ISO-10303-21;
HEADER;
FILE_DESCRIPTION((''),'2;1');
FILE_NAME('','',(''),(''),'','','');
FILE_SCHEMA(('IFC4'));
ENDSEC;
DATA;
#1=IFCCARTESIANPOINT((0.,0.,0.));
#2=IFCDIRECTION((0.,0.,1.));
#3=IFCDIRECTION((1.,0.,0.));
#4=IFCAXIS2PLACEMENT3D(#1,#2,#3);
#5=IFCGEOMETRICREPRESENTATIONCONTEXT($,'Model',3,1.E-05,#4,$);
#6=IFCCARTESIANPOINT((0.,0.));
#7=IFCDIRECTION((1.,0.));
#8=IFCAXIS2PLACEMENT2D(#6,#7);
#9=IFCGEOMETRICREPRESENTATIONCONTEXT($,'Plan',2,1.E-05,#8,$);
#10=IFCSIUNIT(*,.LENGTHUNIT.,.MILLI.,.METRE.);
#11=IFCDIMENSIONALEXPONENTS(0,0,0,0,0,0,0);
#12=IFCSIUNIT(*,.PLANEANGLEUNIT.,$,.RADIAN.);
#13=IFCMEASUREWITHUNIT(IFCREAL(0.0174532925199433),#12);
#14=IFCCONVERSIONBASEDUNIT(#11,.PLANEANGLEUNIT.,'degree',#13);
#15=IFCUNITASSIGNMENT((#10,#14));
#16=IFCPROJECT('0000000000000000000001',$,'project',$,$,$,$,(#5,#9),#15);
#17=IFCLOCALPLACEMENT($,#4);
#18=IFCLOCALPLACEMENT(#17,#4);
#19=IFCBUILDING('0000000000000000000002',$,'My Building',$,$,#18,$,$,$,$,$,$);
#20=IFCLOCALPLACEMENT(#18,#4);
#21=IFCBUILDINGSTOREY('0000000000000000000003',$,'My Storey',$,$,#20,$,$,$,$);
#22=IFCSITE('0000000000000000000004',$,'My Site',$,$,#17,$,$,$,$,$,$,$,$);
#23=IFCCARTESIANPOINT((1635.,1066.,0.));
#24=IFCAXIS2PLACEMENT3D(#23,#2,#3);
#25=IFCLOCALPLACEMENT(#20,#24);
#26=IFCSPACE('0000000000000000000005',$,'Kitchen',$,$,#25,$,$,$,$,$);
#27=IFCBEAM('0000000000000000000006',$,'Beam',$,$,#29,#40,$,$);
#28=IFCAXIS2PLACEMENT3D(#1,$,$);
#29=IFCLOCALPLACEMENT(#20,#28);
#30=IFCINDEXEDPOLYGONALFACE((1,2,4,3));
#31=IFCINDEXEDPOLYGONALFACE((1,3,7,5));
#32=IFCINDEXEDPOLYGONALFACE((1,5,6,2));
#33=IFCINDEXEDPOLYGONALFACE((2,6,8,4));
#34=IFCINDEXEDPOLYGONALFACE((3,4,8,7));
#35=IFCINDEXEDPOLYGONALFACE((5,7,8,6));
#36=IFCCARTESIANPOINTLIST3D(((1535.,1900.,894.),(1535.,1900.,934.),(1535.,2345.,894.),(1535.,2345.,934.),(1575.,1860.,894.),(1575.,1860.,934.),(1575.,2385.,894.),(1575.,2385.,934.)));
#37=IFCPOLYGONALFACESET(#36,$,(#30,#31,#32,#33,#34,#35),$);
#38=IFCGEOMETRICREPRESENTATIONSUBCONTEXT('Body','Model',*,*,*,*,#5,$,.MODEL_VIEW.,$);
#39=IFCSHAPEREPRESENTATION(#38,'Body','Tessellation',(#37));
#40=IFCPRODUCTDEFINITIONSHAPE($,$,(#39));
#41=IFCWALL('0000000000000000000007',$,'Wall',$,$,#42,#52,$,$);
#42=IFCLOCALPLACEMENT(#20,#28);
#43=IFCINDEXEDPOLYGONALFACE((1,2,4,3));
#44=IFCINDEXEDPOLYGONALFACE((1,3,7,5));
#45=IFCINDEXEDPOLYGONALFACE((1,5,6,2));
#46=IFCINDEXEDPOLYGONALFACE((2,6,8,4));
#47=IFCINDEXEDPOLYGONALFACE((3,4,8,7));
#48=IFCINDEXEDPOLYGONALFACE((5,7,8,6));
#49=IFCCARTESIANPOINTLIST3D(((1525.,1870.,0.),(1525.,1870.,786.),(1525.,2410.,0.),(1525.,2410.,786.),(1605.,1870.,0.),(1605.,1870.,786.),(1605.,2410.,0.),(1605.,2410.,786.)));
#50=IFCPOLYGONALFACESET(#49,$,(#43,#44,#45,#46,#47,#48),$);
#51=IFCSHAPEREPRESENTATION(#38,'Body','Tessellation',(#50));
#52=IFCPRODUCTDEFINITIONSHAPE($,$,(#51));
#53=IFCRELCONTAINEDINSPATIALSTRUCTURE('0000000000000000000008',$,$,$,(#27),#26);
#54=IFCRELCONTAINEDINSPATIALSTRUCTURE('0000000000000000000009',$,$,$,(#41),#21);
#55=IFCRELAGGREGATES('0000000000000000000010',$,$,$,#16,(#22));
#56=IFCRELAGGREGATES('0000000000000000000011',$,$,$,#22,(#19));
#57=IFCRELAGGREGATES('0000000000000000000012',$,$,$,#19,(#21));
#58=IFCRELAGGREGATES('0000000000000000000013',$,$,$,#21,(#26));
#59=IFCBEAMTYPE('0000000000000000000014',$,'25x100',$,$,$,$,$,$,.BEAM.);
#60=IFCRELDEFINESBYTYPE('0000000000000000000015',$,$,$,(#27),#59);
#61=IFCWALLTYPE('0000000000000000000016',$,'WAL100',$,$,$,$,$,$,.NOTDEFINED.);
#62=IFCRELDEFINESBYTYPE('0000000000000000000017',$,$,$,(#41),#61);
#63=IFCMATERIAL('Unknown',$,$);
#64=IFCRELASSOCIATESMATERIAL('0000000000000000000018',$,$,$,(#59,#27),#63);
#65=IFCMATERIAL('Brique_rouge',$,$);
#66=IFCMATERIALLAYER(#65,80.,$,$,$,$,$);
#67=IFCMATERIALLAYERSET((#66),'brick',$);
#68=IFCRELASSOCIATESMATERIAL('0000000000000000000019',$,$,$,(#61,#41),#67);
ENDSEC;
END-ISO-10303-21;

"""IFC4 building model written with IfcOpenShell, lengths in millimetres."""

from ifc_helpers import new_model, entity, si_unit, converted_unit, frame, origin_with_axes, origin_2d_with_axis, place, context, subcontext, project, spatial, indexed_curve, rectangle, outline, extrude, clip, halfspace, material, layer, layer_set, layer_usage, material_profile, profile_set, profile_usage, type_object, element, save


model = new_model("IFC4")

# Units and contexts
model_context = context("Model", 3, precision=1e-05, world=origin_with_axes())
plan_context = context("Plan", 2, precision=1e-05, world=origin_2d_with_axis())
body_context = subcontext(model_context, "Body", "Model", "MODEL_VIEW")
ifc_project = project(units=[si_unit("LENGTHUNIT", "METRE", prefix="MILLI"), converted_unit("PLANEANGLEUNIT", "degree", entity("IfcReal", 0.0174532925199433), si_unit("PLANEANGLEUNIT", "RADIAN"), dimensions=[0, 0, 0, 0, 0, 0, 0])], contexts=[model_context, plan_context])

# Site, building, storey, space
site_placement = place(None, origin_with_axes())
site = spatial("IfcSite", under=ifc_project, at=site_placement, Name="My Site")
building_placement = place(site_placement, origin_with_axes())
building = spatial("IfcBuilding", under=site, at=building_placement, Name="My Building")
storey_placement = place(building_placement, origin_with_axes())
storey = spatial("IfcBuildingStorey", under=building, at=storey_placement, Name="My Storey")
space_placement = place(storey_placement, frame((1635.0, 1066.0, 0.0), z_axis=(0.0, 0.0, 1.0), x_axis=(1.0, 0.0, 0.0)))
space = spatial("IfcSpace", under=storey, at=space_placement, Name="Kitchen")

# Shared definitions
ifc_material_1 = material(Name="Unknown")
ifc_material_profile_1 = material_profile(ifc_material_1, rectangle(XDim=40.0, YDim=40.0))
ifc_profile_set_1 = profile_set([ifc_material_profile_1])
beam_type = type_object("IfcBeamType", Name="25x100", PredefinedType="BEAM", material=ifc_profile_set_1)

# Beam
ifc_profile_usage_1 = profile_usage(ifc_profile_set_1)
beam_1_placement = place(space_placement, frame((-80.0, 794.0, 914.0), z_axis=(0.000001, 1.0, 0.0), x_axis=(-1.0, 0.000001, 0.0)))
element("IfcBeam", 1, at=beam_1_placement, inside=space, type_object=beam_type, material=ifc_profile_usage_1, Name="Beam", context=body_context, shape_type="Clipping", body=[
    clip(clip(extrude(rectangle(XDim=40.0, YDim=40.0), origin_with_axes(), (0.0, 0.0, 1.0), 525.0), halfspace(frame((-20.0, -914.0, 0.0), z_axis=(0.707098, 0.0, -0.707116), x_axis=(0.0, -1.0, 0.0)), False)), halfspace(frame((-20.0, -914.0, 525.0), z_axis=(0.707099, 0.0, 0.707115), x_axis=(0.0, -1.0, 0.0)), False)),
])

# Wall
ifc_material_2 = material(Name="Brique_rouge")
ifc_layer_1 = layer(ifc_material_2, 80.0)
ifc_layer_set_1 = layer_set([ifc_layer_1], Name="brick")
ifc_layer_usage_1 = layer_usage(ifc_layer_set_1, "AXIS2", "POSITIVE", 0.0)
wall_type = type_object("IfcWallType", Name="WAL100", PredefinedType="NOTDEFINED", material=ifc_layer_set_1)
wall_placement = place(storey_placement, frame((1605.0, 1870.0, 0.0), z_axis=(0.0, 0.0, 1.0), x_axis=(0.000001, 1.0, 0.0)))
element("IfcWall", 2, at=wall_placement, inside=storey, type_object=wall_type, material=ifc_layer_usage_1, Name="Wall", context=body_context, shape_type="Clipping", body=[
    clip(extrude(outline(indexed_curve([(0.0, 0.0), (0.0, 80.0), (540.0, 80.0), (540.0, 0.0), (0.0, 0.0)], self_intersect=False)), origin_with_axes(), (0.0, 0.0, 1.0), 786.0), halfspace(frame((0.0, 0.0, 786.0), z_axis=(0.0, 0.0, 1.0), x_axis=(-1.0, 0.0, 0.0)), False)),
])

save(model, "model.ifc")
